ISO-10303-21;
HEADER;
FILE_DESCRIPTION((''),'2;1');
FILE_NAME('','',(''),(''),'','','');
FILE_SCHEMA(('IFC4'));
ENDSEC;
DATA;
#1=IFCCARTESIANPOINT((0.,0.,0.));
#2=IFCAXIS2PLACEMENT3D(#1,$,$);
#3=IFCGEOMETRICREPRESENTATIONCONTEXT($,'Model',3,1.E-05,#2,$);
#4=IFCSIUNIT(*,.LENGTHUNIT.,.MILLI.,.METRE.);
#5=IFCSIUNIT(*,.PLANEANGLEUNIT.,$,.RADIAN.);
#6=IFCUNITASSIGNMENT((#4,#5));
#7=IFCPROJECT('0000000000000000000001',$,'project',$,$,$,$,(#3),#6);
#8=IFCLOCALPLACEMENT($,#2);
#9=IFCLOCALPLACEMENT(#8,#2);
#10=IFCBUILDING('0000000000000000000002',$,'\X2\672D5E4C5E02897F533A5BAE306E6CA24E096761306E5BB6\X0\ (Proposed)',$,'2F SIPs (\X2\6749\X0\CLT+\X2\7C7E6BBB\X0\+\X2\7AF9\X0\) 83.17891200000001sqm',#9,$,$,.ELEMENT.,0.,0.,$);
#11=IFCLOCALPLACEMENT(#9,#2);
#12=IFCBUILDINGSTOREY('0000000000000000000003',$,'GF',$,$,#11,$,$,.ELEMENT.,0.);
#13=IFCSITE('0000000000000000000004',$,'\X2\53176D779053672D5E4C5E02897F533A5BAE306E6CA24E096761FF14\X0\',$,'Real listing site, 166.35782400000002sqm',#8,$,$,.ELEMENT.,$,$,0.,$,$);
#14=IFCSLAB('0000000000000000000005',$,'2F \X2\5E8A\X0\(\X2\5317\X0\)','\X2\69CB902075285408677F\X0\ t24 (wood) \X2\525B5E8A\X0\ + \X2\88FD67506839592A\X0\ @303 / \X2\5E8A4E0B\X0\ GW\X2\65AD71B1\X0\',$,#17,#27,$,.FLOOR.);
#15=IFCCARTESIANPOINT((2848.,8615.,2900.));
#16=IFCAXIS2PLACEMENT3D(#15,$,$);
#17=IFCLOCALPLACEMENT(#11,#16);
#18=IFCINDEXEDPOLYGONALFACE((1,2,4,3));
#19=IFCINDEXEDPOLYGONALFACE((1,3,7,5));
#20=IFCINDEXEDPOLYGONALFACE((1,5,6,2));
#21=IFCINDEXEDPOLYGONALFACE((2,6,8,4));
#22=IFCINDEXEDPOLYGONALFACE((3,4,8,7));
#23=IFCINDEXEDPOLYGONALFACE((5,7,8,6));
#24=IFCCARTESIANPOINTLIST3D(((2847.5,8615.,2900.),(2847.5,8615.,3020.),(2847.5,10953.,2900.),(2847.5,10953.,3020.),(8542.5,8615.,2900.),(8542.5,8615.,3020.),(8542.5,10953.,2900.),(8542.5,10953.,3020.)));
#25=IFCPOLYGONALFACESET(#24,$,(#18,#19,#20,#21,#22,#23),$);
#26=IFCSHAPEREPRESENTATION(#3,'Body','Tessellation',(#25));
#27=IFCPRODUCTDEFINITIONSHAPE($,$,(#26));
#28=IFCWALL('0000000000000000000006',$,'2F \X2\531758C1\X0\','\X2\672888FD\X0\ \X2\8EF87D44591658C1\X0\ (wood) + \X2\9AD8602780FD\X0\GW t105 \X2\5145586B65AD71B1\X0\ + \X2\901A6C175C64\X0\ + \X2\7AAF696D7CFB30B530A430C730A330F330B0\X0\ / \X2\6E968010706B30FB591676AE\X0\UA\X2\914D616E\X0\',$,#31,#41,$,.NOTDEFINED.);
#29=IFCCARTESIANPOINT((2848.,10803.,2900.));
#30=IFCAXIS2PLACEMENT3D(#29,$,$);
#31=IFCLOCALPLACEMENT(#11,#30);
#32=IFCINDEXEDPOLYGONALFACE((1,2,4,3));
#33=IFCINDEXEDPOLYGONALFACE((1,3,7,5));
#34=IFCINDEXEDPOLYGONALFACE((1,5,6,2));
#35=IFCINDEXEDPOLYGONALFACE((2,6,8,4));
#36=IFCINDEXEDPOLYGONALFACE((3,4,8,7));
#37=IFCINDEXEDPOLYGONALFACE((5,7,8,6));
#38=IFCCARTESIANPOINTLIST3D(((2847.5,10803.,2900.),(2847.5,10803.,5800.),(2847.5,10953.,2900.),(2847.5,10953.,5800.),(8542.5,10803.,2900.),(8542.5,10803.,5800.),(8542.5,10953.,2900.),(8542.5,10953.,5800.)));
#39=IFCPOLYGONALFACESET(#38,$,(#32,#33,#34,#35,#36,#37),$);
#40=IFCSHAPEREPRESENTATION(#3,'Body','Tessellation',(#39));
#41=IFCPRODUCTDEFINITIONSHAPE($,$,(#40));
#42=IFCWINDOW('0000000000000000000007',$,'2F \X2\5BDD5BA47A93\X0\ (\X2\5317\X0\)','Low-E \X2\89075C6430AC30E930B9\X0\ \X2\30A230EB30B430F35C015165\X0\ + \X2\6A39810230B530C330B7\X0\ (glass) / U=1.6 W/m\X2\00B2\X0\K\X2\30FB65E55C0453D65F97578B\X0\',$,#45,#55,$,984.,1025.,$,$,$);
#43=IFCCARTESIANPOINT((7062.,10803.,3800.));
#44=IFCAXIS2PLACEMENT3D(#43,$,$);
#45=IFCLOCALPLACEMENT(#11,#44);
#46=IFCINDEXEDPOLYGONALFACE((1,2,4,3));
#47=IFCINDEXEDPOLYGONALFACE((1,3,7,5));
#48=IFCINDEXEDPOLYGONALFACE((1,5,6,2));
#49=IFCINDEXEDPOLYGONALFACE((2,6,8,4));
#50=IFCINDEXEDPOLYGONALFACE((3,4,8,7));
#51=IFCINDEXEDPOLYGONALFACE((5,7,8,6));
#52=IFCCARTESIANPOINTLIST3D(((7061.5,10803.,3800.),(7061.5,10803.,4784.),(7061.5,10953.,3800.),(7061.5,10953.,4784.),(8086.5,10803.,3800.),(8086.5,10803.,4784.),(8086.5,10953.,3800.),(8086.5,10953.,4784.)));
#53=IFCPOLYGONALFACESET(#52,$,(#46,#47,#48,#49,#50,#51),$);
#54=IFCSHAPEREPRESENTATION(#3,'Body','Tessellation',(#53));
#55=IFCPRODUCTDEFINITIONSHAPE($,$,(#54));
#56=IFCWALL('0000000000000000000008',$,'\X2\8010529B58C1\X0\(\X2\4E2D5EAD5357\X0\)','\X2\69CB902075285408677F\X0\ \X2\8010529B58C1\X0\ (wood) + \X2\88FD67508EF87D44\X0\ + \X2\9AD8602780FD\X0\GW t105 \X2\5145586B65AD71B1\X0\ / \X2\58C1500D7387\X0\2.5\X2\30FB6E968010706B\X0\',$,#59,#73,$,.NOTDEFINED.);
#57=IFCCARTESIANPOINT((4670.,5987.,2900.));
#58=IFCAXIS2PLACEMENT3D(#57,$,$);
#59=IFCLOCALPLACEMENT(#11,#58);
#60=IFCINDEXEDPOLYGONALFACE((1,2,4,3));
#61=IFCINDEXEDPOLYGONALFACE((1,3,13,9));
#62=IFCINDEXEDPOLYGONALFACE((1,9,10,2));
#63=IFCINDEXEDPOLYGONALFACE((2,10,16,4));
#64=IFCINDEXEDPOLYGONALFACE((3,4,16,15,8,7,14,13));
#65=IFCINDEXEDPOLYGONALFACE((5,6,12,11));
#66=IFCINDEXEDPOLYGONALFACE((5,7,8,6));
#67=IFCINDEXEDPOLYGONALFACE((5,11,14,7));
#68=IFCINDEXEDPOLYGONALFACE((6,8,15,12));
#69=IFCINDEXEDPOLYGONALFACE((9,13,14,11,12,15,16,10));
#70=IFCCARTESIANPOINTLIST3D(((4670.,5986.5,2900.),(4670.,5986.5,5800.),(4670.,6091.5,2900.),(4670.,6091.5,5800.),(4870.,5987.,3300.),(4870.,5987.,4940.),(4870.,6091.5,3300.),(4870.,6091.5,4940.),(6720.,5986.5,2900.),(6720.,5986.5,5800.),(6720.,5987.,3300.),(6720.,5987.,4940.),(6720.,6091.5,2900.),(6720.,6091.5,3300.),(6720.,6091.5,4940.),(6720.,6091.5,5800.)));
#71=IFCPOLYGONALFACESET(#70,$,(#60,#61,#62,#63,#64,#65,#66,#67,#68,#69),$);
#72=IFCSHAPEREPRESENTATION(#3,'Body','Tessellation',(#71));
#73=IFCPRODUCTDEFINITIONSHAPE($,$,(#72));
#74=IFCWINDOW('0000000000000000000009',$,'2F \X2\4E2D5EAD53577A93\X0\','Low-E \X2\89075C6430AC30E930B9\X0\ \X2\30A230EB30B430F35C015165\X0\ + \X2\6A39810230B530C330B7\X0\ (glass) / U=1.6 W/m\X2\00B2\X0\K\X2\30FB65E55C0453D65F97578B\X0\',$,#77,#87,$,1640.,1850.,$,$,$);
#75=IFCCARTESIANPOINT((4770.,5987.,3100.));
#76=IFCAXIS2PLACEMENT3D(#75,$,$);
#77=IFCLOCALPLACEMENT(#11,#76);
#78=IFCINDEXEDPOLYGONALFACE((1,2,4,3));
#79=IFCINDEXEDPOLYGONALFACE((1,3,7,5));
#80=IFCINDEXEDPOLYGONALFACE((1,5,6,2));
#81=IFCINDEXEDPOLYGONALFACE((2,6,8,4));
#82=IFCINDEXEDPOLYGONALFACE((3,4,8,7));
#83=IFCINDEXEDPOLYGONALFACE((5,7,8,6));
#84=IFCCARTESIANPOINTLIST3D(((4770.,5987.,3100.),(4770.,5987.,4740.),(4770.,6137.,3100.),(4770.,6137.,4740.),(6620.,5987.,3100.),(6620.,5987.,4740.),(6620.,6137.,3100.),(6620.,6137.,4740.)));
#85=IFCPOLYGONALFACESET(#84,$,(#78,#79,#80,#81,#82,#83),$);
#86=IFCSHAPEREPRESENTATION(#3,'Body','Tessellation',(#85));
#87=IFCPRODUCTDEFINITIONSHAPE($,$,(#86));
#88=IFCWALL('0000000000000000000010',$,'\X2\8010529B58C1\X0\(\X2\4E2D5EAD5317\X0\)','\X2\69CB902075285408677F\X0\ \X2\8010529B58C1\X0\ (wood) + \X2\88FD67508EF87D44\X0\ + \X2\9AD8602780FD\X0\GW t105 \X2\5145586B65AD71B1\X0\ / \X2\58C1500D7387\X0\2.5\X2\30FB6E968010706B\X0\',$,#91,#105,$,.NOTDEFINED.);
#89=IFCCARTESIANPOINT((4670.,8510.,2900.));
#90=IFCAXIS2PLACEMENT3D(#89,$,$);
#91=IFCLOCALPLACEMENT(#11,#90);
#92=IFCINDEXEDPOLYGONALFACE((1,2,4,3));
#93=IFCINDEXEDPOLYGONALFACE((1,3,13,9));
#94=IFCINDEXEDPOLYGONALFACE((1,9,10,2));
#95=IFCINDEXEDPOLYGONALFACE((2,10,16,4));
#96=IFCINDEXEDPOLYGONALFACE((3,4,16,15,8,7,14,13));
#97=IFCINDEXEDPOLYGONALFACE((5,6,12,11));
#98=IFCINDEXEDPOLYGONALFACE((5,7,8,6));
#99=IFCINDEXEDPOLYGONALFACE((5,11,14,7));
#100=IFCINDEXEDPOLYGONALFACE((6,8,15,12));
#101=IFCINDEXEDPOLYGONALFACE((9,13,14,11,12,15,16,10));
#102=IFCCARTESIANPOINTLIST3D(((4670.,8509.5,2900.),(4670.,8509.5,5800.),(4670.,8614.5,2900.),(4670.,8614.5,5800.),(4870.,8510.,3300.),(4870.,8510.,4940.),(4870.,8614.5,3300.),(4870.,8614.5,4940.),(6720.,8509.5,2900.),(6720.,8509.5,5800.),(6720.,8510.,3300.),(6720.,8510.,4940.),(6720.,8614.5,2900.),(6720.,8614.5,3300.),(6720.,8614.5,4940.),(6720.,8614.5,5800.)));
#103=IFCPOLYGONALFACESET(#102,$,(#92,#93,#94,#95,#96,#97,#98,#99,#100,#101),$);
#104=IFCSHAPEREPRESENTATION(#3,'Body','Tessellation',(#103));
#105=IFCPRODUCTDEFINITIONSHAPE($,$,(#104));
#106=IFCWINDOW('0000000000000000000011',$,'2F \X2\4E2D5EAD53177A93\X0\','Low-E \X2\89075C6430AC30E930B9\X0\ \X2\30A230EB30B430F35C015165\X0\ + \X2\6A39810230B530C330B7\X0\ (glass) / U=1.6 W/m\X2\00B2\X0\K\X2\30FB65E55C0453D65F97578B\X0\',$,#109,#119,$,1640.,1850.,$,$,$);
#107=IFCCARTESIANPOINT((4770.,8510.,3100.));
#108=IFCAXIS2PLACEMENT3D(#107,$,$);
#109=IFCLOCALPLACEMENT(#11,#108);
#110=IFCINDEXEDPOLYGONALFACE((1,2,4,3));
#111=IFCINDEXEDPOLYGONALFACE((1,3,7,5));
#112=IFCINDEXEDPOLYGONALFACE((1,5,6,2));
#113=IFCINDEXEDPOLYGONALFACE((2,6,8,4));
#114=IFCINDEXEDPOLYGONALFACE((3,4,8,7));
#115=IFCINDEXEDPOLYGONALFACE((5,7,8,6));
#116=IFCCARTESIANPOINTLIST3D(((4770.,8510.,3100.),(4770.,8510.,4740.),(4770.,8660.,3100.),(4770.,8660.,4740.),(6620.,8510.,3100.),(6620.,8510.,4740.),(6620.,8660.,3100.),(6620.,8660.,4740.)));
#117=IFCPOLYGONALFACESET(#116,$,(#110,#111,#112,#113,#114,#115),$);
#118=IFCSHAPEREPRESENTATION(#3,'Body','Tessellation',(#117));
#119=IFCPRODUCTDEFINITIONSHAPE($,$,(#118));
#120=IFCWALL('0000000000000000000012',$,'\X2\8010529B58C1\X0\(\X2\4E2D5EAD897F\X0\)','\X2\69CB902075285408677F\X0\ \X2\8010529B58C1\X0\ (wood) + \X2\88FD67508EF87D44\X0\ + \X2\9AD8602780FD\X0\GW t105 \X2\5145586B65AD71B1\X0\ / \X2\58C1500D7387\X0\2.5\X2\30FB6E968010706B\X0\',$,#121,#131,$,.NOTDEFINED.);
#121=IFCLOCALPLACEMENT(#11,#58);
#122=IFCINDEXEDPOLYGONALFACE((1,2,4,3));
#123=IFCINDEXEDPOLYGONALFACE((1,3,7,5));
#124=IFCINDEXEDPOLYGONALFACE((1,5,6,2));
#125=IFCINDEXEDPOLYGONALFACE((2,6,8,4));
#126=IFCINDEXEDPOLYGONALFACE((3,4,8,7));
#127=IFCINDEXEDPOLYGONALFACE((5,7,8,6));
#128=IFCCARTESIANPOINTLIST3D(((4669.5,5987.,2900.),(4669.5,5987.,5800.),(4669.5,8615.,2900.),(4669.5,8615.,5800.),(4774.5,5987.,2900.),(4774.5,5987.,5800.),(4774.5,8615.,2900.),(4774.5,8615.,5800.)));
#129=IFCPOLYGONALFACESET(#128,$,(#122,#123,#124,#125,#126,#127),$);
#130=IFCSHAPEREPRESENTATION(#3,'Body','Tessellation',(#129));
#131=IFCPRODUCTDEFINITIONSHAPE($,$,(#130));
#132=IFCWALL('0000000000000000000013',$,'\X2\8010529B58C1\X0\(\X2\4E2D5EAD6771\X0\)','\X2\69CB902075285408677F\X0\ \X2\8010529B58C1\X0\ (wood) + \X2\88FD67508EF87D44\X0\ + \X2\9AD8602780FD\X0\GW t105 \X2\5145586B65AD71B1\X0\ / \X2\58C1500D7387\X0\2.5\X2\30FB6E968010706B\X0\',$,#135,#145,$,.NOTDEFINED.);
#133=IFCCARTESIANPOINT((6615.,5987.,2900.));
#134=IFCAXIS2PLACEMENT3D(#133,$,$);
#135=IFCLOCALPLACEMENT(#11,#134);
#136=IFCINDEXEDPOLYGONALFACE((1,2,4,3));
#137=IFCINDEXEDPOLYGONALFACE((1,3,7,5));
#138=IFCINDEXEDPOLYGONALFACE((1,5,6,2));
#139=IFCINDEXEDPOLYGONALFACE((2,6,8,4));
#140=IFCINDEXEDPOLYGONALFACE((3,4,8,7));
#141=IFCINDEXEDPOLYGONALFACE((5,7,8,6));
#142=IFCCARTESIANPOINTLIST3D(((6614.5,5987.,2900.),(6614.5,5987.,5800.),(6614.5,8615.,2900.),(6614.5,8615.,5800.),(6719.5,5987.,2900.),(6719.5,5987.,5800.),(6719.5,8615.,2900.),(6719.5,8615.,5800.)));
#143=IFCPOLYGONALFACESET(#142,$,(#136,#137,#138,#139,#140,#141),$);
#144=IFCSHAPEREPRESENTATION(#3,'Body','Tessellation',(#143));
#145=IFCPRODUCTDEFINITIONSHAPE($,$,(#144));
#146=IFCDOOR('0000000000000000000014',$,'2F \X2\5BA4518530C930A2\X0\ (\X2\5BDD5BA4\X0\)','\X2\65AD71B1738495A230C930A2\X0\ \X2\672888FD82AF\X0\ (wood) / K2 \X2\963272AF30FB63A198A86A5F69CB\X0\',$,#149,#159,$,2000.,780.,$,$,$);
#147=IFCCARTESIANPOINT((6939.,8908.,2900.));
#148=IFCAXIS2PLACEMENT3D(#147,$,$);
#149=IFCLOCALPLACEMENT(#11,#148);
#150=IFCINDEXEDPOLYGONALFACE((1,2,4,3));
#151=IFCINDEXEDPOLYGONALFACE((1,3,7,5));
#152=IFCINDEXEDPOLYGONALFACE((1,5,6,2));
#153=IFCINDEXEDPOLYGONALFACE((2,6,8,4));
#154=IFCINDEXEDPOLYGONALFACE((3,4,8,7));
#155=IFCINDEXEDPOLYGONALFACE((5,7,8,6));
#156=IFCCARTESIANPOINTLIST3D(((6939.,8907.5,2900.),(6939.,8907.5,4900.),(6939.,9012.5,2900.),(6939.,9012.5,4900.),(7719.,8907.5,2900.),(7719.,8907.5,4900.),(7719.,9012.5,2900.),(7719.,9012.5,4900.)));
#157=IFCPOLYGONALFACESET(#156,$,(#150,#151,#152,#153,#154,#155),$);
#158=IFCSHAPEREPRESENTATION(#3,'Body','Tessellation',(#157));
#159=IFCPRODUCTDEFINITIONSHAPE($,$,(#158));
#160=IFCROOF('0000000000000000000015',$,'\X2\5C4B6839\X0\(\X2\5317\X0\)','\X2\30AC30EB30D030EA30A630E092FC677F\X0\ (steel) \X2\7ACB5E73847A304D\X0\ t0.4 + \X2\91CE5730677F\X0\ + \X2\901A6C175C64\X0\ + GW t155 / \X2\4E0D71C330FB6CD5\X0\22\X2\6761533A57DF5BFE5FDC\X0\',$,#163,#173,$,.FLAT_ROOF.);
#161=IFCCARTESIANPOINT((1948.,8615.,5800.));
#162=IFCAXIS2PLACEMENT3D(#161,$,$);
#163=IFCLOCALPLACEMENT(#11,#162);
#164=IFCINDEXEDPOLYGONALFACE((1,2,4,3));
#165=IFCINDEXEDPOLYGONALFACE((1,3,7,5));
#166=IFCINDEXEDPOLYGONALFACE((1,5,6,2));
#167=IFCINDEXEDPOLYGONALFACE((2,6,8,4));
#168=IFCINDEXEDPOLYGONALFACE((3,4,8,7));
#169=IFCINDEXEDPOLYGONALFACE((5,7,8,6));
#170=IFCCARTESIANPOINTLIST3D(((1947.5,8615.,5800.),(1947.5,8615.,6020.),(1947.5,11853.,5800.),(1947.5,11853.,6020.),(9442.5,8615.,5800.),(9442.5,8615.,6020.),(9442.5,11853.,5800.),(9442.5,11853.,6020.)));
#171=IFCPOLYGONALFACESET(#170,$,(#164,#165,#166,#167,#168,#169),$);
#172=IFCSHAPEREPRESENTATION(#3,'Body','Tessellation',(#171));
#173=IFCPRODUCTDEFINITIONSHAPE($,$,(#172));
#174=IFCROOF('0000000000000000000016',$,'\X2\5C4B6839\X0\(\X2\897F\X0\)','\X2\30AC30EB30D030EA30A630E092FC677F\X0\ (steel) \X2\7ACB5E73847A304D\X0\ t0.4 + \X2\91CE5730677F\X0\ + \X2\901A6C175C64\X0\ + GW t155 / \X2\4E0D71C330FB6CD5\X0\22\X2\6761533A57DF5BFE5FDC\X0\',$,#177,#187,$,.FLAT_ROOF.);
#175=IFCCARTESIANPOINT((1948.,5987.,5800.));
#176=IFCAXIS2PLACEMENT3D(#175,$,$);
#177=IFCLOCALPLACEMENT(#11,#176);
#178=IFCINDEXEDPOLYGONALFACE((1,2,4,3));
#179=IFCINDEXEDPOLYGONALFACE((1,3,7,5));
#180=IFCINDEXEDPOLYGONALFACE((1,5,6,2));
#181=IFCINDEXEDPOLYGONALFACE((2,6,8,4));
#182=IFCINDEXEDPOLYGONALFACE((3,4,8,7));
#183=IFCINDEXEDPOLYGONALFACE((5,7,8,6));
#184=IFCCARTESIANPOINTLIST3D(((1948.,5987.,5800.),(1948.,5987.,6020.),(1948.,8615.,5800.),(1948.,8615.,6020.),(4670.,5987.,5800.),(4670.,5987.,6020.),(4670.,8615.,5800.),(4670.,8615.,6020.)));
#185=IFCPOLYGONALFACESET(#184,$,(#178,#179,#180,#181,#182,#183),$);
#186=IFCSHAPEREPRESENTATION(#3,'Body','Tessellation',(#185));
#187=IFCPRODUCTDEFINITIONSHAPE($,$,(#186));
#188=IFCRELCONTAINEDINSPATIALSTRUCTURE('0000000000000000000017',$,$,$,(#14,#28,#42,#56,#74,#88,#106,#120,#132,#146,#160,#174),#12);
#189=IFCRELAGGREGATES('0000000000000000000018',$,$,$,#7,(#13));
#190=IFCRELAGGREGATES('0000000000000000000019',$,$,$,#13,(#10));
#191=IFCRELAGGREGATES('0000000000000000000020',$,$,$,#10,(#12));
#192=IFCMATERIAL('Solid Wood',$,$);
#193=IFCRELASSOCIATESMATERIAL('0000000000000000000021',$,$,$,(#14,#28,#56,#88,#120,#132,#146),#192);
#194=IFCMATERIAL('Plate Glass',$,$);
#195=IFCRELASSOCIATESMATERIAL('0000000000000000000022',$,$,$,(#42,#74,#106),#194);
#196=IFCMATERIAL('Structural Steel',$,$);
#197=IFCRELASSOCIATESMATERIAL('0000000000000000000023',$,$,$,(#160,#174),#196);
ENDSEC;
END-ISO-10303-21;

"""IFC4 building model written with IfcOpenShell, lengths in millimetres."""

from ifc_helpers import new_model, si_unit, frame, frame_2d, origin, place, context, project, spatial, rectangle, extrude, material, element, fill, save


model = new_model("IFC4")

# Units and contexts
model_context = context("Model", 3, precision=1e-05, world=origin())
ifc_project = project(units=[si_unit("LENGTHUNIT", "METRE", prefix="MILLI"), si_unit("PLANEANGLEUNIT", "RADIAN")], contexts=[model_context])

# Site, building, storey
site_placement = place(None, origin())
site = spatial("IfcSite", under=ifc_project, at=site_placement, Name="北海道札幌市西区宮の沢三条４", ObjectType="Real listing site, 166.35782400000002sqm", CompositionType="ELEMENT", RefElevation=0.0)
building_placement = place(site_placement, origin())
building = spatial("IfcBuilding", under=site, at=building_placement, Name="札幌市西区宮の沢三条の家 (Proposed)", ObjectType="2F SIPs (杉CLT+籾殻+竹) 83.17891200000001sqm", CompositionType="ELEMENT", ElevationOfRefHeight=0.0, ElevationOfTerrain=0.0)
storey_placement = place(building_placement, origin())
storey = spatial("IfcBuildingStorey", under=building, at=storey_placement, Name="GF", CompositionType="ELEMENT", Elevation=0.0)

# Slab
ifc_material_1 = material(Name="Solid Wood")
slab_placement = place(storey_placement, frame((2848.0, 8615.0, 2900.0)))
element("IfcSlab", 1, at=slab_placement, inside=storey, material=ifc_material_1, Name="2F 床(北)", Description="構造用合板 t24 (wood) 剛床 + 製材根太 @303 / 床下 GW断熱", PredefinedType="FLOOR", context=model_context, shape_type="SweptSolid", body=[
    extrude(rectangle(XDim=5695.0, YDim=2338.0, at=frame_2d((2847.0, 1169.0))), frame((2848.0, 8615.0, 2900.0)), (0.0, 0.0, 1.0), 120.0),
])

# Walls, openings, windows
wall_1_placement = place(storey_placement, frame((2848.0, 10803.0, 2900.0)))
wall_1 = element("IfcWall", 2, at=wall_1_placement, inside=storey, material=ifc_material_1, Name="2F 北壁", Description="木製 軸組外壁 (wood) + 高性能GW t105 充填断熱 + 通気層 + 窯業系サイディング / 準耐火・外皮UA配慮", PredefinedType="NOTDEFINED", context=model_context, shape_type="SweptSolid", body=[
    extrude(rectangle(XDim=5695.0, YDim=150.0, at=frame_2d((2847.0, 75.0))), frame((2848.0, 10803.0, 2900.0)), (0.0, 0.0, 1.0), 2900.0),
])
opening_1_placement = place(storey_placement, frame((7062.0, 10803.0, 3800.0)))
opening_1 = element("IfcOpeningElement", 3, at=opening_1_placement, cuts=wall_1, PredefinedType="NOTDEFINED", context=model_context, shape_type="SweptSolid", body=[
    extrude(rectangle(XDim=1025.0, YDim=150.0, at=frame_2d((512.0, 75.0))), frame((7062.0, 10803.0, 3800.0)), (0.0, 0.0, 1.0), 984.0),
])
ifc_material_2 = material(Name="Plate Glass")
window_1_placement = place(storey_placement, frame((7062.0, 10803.0, 3800.0)))
window_1 = element("IfcWindow", 4, at=window_1_placement, inside=storey, material=ifc_material_2, Name="2F 寝室窓 (北)", Description="Low-E 複層ガラス アルゴン封入 + 樹脂サッシ (glass) / U=1.6 W/m²K・日射取得型", OverallHeight=984.0, OverallWidth=1025.0, context=model_context, shape_type="SweptSolid", body=[
    extrude(rectangle(XDim=1025.0, YDim=150.0, at=frame_2d((512.0, 75.0))), frame((7062.0, 10803.0, 3800.0)), (0.0, 0.0, 1.0), 984.0),
])
fill(opening_1, window_1)
wall_2_placement = place(storey_placement, frame((4670.0, 5987.0, 2900.0)))
wall_2 = element("IfcWall", 5, at=wall_2_placement, inside=storey, material=ifc_material_1, Name="耐力壁(中庭南)", Description="構造用合板 耐力壁 (wood) + 製材軸組 + 高性能GW t105 充填断熱 / 壁倍率2.5・準耐火", PredefinedType="NOTDEFINED", context=model_context, shape_type="SweptSolid", body=[
    extrude(rectangle(XDim=2050.0, YDim=105.0, at=frame_2d((1025.0, 52.0))), frame((4670.0, 5987.0, 2900.0)), (0.0, 0.0, 1.0), 2900.0),
])
opening_2_placement = place(storey_placement, frame((4770.0, 5987.0, 3100.0)))
opening_2 = element("IfcOpeningElement", 6, at=opening_2_placement, cuts=wall_2, PredefinedType="NOTDEFINED", context=model_context, shape_type="SweptSolid", body=[
    extrude(rectangle(XDim=1850.0, YDim=150.0, at=frame_2d((925.0, 75.0))), frame((4770.0, 5987.0, 3100.0)), (0.0, 0.0, 1.0), 1640.0),
])
window_2_placement = place(storey_placement, frame((4770.0, 5987.0, 3100.0)))
window_2 = element("IfcWindow", 7, at=window_2_placement, inside=storey, material=ifc_material_2, Name="2F 中庭南窓", Description="Low-E 複層ガラス アルゴン封入 + 樹脂サッシ (glass) / U=1.6 W/m²K・日射取得型", OverallHeight=1640.0, OverallWidth=1850.0, context=model_context, shape_type="SweptSolid", body=[
    extrude(rectangle(XDim=1850.0, YDim=150.0, at=frame_2d((925.0, 75.0))), frame((4770.0, 5987.0, 3100.0)), (0.0, 0.0, 1.0), 1640.0),
])
fill(opening_2, window_2)
wall_3_placement = place(storey_placement, frame((4670.0, 8510.0, 2900.0)))
wall_3 = element("IfcWall", 8, at=wall_3_placement, inside=storey, material=ifc_material_1, Name="耐力壁(中庭北)", Description="構造用合板 耐力壁 (wood) + 製材軸組 + 高性能GW t105 充填断熱 / 壁倍率2.5・準耐火", PredefinedType="NOTDEFINED", context=model_context, shape_type="SweptSolid", body=[
    extrude(rectangle(XDim=2050.0, YDim=105.0, at=frame_2d((1025.0, 52.0))), frame((4670.0, 8510.0, 2900.0)), (0.0, 0.0, 1.0), 2900.0),
])
opening_3_placement = place(storey_placement, frame((4770.0, 8510.0, 3100.0)))
opening_3 = element("IfcOpeningElement", 9, at=opening_3_placement, cuts=wall_3, PredefinedType="NOTDEFINED", context=model_context, shape_type="SweptSolid", body=[
    extrude(rectangle(XDim=1850.0, YDim=150.0, at=frame_2d((925.0, 75.0))), frame((4770.0, 8510.0, 3100.0)), (0.0, 0.0, 1.0), 1640.0),
])
window_3_placement = place(storey_placement, frame((4770.0, 8510.0, 3100.0)))
window_3 = element("IfcWindow", 10, at=window_3_placement, inside=storey, material=ifc_material_2, Name="2F 中庭北窓", Description="Low-E 複層ガラス アルゴン封入 + 樹脂サッシ (glass) / U=1.6 W/m²K・日射取得型", OverallHeight=1640.0, OverallWidth=1850.0, context=model_context, shape_type="SweptSolid", body=[
    extrude(rectangle(XDim=1850.0, YDim=150.0, at=frame_2d((925.0, 75.0))), frame((4770.0, 8510.0, 3100.0)), (0.0, 0.0, 1.0), 1640.0),
])
fill(opening_3, window_3)

# Walls
wall_4_placement = place(storey_placement, frame((4670.0, 5987.0, 2900.0)))
element("IfcWall", 11, at=wall_4_placement, inside=storey, material=ifc_material_1, Name="耐力壁(中庭西)", Description="構造用合板 耐力壁 (wood) + 製材軸組 + 高性能GW t105 充填断熱 / 壁倍率2.5・準耐火", PredefinedType="NOTDEFINED", context=model_context, shape_type="SweptSolid", body=[
    extrude(rectangle(XDim=105.0, YDim=2628.0, at=frame_2d((52.0, 1314.0))), frame((4670.0, 5987.0, 2900.0)), (0.0, 0.0, 1.0), 2900.0),
])
wall_5_placement = place(storey_placement, frame((6615.0, 5987.0, 2900.0)))
element("IfcWall", 12, at=wall_5_placement, inside=storey, material=ifc_material_1, Name="耐力壁(中庭東)", Description="構造用合板 耐力壁 (wood) + 製材軸組 + 高性能GW t105 充填断熱 / 壁倍率2.5・準耐火", PredefinedType="NOTDEFINED", context=model_context, shape_type="SweptSolid", body=[
    extrude(rectangle(XDim=105.0, YDim=2628.0, at=frame_2d((52.0, 1314.0))), frame((6615.0, 5987.0, 2900.0)), (0.0, 0.0, 1.0), 2900.0),
])

# Door
door_placement = place(storey_placement, frame((6939.0, 8908.0, 2900.0)))
element("IfcDoor", 13, at=door_placement, inside=storey, material=ifc_material_1, Name="2F 室内ドア (寝室)", Description="断熱玄関ドア 木製芯 (wood) / K2 防犯・採風機構", OverallHeight=2000.0, OverallWidth=780.0, context=model_context, shape_type="SweptSolid", body=[
    extrude(rectangle(XDim=780.0, YDim=105.0, at=frame_2d((390.0, 52.0))), frame((6939.0, 8908.0, 2900.0)), (0.0, 0.0, 1.0), 2000.0),
])

# Roofs
ifc_material_3 = material(Name="Structural Steel")
for number, where, name in (
    (14, (1948.0, 8615.0, 5800.0), "屋根(北)"),
):
    element("IfcRoof", number, at=place(storey_placement, frame(where)), inside=storey, material=ifc_material_3, Name=name, Description="ガルバリウム鋼板 (steel) 立平葺き t0.4 + 野地板 + 通気層 + GW t155 / 不燃・法22条区域対応", PredefinedType="FLAT_ROOF", context=model_context, shape_type="SweptSolid", body=[
        extrude(rectangle(XDim=7495.0, YDim=3238.0, at=frame_2d((3747.0, 1619.0))), frame((1948.0, 8615.0, 5800.0)), (0.0, 0.0, 1.0), 220.0),
    ])
roof_1_placement = place(storey_placement, frame((1948.0, 5987.0, 5800.0)))
element("IfcRoof", 15, at=roof_1_placement, inside=storey, material=ifc_material_3, Name="屋根(西)", Description="ガルバリウム鋼板 (steel) 立平葺き t0.4 + 野地板 + 通気層 + GW t155 / 不燃・法22条区域対応", PredefinedType="FLAT_ROOF", context=model_context, shape_type="SweptSolid", body=[
    extrude(rectangle(XDim=2722.0, YDim=2628.0, at=frame_2d((1361.0, 1314.0))), frame((1948.0, 5987.0, 5800.0)), (0.0, 0.0, 1.0), 220.0),
])

save(model, "model.ifc")
